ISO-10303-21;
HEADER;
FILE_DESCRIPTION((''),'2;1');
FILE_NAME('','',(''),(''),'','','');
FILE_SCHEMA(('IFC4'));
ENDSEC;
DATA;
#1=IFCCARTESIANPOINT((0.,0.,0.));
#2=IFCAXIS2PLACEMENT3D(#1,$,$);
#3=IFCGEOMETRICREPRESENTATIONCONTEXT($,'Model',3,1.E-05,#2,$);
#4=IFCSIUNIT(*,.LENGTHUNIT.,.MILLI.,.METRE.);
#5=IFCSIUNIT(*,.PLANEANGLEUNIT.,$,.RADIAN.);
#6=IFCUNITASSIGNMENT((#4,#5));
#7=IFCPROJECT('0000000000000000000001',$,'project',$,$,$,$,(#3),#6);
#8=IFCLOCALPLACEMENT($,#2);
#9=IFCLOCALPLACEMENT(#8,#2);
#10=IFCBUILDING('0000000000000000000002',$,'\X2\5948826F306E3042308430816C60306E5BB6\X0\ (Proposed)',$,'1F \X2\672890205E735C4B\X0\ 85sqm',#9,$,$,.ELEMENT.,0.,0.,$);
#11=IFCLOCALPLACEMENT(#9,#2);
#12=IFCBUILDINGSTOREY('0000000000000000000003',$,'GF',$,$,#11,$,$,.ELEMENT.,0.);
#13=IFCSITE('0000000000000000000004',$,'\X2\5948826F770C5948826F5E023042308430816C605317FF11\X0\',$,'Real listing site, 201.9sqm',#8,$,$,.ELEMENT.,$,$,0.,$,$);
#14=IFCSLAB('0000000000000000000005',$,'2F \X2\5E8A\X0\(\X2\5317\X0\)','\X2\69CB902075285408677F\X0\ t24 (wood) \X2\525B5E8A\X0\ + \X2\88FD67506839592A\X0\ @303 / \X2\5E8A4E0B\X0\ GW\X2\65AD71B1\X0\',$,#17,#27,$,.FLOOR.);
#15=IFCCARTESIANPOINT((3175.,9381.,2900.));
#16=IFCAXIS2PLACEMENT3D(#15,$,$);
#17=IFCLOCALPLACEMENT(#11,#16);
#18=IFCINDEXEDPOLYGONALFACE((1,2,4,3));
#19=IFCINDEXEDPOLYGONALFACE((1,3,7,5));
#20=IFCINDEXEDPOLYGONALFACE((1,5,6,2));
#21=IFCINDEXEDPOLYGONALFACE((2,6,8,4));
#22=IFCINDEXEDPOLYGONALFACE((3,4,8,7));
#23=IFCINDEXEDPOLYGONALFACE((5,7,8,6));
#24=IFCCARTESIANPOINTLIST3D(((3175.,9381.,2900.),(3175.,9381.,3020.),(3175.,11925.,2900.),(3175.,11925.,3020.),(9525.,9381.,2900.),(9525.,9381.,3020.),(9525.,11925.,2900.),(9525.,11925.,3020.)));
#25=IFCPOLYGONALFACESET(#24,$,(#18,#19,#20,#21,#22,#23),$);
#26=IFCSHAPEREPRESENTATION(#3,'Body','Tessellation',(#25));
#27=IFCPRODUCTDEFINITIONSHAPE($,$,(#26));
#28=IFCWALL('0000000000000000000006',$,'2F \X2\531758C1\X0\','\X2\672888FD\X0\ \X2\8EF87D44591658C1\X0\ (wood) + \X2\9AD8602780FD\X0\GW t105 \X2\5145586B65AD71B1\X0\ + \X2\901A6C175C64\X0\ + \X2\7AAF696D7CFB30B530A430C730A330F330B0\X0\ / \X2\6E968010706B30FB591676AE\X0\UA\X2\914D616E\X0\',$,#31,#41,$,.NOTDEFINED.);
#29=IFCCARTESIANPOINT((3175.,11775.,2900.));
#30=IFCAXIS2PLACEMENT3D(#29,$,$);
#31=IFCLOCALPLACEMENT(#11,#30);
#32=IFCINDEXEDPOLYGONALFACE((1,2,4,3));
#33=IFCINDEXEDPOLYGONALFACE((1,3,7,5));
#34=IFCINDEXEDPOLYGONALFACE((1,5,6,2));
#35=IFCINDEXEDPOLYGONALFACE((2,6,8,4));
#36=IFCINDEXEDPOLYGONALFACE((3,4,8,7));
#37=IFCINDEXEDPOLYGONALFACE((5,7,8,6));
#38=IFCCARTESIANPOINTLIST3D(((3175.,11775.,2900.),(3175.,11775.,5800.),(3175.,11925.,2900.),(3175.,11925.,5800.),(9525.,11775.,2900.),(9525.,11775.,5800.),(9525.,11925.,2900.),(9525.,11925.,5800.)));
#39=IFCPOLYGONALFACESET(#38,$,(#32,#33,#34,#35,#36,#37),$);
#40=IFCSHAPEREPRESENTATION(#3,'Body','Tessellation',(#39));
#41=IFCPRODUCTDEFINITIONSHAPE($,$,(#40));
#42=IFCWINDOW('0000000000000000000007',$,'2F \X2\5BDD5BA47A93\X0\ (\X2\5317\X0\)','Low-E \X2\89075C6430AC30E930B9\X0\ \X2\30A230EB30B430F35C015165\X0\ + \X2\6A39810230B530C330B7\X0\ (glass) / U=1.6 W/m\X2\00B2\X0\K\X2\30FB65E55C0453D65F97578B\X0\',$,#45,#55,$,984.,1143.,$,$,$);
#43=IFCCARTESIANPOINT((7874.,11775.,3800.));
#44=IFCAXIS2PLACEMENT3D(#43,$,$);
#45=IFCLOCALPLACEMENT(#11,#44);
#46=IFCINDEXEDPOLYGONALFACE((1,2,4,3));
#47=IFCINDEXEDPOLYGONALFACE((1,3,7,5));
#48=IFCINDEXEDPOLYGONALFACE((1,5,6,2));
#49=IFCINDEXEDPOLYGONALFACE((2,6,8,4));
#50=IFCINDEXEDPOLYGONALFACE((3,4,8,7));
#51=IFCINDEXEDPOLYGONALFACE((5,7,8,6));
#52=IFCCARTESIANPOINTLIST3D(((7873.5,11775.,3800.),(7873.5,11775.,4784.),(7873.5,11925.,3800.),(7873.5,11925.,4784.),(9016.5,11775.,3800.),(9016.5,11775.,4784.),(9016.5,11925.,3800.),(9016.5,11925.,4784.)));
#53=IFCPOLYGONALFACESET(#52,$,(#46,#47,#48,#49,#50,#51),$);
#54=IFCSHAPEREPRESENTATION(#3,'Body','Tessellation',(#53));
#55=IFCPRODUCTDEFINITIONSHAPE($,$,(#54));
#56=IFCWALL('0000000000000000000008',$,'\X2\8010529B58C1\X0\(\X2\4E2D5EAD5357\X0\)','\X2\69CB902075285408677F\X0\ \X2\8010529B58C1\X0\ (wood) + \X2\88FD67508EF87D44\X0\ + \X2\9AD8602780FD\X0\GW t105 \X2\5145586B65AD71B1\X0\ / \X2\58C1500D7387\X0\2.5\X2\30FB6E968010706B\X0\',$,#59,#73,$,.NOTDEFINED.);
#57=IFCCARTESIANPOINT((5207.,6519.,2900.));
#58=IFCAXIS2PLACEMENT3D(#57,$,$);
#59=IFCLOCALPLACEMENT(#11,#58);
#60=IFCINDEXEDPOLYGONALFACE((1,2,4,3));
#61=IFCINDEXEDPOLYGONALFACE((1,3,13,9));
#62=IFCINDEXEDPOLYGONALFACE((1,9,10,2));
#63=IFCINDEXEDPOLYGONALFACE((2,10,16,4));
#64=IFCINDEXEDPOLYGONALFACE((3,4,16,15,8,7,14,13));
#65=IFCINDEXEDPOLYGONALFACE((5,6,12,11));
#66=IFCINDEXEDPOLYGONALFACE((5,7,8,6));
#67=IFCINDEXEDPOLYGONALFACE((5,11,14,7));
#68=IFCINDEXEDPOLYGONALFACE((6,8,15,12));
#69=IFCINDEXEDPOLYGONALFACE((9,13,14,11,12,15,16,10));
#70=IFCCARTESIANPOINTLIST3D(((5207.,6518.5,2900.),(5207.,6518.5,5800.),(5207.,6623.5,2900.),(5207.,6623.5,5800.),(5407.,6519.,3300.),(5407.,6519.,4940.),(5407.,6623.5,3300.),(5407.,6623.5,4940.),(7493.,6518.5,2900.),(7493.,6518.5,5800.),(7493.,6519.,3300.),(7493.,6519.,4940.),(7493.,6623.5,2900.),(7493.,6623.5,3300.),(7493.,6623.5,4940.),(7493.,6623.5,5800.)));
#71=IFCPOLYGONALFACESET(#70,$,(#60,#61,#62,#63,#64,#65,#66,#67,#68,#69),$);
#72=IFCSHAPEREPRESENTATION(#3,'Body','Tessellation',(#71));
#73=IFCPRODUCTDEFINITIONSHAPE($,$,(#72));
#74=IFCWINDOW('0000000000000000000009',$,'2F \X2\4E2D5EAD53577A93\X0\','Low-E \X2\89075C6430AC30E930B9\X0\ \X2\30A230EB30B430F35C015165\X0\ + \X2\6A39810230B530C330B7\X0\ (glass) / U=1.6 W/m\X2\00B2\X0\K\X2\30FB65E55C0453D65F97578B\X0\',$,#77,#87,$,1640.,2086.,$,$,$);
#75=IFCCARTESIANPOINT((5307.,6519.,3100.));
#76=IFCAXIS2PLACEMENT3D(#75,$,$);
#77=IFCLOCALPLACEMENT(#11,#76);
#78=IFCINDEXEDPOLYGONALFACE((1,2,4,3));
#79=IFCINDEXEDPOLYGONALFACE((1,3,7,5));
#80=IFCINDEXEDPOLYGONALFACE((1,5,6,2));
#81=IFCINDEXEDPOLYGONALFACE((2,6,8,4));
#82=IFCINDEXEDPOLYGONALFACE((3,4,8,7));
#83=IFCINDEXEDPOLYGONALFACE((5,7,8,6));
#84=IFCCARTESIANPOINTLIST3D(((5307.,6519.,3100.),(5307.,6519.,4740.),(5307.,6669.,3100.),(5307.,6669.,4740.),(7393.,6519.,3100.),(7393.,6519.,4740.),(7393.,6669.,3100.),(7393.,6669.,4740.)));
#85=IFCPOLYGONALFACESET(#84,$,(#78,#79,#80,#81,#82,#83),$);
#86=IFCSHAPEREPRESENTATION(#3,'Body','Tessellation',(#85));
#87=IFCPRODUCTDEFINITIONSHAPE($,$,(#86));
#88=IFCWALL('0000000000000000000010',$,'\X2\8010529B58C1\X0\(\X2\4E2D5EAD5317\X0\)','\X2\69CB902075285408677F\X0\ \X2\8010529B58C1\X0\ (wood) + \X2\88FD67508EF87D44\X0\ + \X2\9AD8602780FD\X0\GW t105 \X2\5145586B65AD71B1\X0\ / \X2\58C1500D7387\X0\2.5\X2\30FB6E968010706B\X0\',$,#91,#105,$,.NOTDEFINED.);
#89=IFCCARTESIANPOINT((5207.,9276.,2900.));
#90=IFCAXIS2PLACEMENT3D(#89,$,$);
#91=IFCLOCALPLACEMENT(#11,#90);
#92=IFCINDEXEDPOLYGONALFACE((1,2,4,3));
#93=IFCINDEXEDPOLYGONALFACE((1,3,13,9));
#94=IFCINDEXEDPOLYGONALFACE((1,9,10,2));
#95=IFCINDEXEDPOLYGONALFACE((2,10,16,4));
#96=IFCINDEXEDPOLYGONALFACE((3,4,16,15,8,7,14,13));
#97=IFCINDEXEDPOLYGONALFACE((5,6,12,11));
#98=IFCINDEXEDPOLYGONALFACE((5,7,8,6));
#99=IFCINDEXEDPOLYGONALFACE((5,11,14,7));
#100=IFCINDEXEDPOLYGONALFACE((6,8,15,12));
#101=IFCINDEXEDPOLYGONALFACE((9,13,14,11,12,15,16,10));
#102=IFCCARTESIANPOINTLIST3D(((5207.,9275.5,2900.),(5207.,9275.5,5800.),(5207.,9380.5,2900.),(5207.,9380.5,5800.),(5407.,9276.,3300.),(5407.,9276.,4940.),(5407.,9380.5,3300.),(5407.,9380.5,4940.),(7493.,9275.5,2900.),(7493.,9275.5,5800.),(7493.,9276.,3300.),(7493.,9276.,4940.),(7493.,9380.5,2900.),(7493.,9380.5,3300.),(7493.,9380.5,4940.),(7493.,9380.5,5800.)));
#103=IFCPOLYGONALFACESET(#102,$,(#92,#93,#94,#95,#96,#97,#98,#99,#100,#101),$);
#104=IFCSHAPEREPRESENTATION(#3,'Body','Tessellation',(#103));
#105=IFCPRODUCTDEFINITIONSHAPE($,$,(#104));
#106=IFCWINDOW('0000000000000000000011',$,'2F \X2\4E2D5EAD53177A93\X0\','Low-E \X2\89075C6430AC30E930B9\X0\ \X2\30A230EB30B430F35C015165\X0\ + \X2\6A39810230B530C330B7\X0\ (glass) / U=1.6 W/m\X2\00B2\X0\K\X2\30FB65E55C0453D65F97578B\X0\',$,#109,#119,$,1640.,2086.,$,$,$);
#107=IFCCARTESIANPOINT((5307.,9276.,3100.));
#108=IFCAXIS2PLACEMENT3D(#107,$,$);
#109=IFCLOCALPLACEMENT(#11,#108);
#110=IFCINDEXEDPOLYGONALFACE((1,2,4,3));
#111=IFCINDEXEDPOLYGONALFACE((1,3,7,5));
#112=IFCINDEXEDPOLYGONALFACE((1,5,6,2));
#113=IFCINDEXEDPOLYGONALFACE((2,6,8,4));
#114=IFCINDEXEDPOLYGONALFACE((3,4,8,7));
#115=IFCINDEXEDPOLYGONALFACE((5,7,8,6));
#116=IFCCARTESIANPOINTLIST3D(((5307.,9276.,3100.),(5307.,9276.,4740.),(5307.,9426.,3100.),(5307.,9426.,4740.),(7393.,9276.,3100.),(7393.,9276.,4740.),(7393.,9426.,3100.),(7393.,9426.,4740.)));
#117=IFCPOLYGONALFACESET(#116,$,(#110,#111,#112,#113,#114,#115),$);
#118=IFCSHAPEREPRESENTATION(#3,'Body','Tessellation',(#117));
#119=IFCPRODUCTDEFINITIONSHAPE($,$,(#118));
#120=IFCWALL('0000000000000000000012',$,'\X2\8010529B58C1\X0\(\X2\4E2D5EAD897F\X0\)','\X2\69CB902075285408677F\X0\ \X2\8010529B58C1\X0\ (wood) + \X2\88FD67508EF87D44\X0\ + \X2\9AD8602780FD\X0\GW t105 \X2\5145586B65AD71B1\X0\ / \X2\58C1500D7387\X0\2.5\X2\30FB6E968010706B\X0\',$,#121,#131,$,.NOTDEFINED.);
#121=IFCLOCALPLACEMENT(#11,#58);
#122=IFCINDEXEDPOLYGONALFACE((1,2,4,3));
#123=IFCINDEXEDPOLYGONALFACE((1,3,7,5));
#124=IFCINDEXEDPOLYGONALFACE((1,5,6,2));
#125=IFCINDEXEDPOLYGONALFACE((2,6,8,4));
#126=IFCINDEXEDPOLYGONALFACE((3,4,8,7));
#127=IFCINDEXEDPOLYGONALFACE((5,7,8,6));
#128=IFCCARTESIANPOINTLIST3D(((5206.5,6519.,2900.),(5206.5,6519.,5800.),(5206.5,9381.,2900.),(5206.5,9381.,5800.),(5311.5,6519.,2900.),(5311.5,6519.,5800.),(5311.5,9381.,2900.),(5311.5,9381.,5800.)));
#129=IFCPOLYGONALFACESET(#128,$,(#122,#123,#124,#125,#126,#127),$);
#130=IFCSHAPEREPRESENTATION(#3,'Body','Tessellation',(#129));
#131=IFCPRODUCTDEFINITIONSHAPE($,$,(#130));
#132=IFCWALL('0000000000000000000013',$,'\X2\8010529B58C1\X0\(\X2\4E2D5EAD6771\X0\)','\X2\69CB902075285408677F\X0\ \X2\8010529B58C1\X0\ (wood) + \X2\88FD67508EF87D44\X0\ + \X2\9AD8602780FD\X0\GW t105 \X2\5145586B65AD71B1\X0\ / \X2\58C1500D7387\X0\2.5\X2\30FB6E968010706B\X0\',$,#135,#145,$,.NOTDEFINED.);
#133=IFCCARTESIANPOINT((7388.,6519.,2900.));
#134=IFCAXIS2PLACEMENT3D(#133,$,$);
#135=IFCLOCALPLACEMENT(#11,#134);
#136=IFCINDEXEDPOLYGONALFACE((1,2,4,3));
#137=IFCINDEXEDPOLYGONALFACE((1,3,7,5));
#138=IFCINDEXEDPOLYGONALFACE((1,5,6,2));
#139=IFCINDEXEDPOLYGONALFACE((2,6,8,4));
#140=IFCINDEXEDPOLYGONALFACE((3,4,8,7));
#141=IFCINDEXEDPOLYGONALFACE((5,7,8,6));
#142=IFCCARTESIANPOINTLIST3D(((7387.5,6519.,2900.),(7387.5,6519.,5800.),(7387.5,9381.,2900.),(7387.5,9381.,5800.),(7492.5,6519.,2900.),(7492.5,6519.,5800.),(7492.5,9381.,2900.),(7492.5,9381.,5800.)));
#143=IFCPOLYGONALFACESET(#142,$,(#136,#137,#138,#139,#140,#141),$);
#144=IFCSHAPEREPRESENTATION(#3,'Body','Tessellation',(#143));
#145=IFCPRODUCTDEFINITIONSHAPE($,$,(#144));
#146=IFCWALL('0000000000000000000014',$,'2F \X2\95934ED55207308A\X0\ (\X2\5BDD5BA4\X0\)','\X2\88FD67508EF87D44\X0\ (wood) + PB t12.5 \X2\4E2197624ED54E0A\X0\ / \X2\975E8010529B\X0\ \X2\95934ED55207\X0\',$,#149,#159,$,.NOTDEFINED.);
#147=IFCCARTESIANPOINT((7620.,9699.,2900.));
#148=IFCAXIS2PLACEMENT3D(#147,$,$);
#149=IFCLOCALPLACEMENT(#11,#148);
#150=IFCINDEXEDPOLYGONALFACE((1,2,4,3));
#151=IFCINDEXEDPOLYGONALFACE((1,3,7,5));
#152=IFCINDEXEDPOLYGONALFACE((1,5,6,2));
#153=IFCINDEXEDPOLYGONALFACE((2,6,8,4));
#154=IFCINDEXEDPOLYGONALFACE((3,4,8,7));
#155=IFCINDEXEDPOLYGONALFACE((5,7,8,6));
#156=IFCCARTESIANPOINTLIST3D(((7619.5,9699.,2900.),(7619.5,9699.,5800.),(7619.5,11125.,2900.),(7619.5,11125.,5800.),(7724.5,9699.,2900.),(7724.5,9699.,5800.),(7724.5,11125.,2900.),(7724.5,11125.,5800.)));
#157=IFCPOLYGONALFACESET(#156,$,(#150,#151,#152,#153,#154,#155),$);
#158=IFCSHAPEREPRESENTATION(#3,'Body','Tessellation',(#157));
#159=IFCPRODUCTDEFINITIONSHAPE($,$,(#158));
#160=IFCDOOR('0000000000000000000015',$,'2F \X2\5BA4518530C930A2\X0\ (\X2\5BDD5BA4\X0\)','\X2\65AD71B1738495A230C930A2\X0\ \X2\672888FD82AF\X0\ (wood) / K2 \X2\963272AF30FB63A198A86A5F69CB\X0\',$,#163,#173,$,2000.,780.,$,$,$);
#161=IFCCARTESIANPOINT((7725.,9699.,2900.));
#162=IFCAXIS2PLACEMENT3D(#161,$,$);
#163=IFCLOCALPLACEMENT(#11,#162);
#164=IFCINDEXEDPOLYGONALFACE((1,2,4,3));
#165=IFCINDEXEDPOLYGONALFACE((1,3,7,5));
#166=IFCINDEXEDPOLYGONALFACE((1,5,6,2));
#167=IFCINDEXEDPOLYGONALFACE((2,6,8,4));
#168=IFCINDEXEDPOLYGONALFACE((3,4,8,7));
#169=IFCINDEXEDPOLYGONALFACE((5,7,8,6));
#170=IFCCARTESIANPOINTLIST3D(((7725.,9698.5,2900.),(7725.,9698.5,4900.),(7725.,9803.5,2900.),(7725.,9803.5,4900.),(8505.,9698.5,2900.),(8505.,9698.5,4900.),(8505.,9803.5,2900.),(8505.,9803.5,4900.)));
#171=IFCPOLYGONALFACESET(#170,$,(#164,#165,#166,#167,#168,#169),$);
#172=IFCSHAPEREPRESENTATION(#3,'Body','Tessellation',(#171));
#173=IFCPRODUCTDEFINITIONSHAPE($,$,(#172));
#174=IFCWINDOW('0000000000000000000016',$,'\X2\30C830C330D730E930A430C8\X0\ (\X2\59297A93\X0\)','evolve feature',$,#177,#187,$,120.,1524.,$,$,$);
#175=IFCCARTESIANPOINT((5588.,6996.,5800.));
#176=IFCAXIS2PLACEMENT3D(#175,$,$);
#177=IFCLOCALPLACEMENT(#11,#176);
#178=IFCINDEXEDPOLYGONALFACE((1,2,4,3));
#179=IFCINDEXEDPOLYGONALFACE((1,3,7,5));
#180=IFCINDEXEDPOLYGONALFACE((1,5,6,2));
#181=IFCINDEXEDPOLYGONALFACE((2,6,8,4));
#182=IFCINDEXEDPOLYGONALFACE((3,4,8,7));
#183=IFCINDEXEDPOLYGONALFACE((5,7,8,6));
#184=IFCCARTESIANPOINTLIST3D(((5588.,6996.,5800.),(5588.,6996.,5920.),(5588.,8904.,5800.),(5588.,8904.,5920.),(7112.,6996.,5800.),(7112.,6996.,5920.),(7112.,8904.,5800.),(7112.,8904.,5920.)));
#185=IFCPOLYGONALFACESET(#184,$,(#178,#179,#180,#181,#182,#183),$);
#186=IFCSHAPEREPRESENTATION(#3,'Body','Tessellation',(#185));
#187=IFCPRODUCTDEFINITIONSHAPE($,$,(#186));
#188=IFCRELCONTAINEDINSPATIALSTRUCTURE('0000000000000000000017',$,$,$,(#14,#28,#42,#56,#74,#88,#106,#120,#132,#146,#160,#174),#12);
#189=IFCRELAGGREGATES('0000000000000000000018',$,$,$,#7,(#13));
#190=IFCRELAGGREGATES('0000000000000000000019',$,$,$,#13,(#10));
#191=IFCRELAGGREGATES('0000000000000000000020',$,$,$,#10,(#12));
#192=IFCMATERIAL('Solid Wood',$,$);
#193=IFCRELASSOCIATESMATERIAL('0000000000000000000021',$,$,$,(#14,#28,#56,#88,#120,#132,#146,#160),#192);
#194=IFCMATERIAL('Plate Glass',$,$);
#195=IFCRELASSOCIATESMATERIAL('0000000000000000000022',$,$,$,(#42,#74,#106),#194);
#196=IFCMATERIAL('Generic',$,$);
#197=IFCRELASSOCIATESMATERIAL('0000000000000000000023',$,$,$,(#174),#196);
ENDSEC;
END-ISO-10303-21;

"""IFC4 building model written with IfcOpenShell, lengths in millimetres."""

from ifc_helpers import new_model, si_unit, frame, frame_2d, origin, place, context, project, spatial, rectangle, extrude, material, element, fill, save


model = new_model("IFC4")

# Units and contexts
model_context = context("Model", 3, precision=1e-05, world=origin())
ifc_project = project(units=[si_unit("LENGTHUNIT", "METRE", prefix="MILLI"), si_unit("PLANEANGLEUNIT", "RADIAN")], contexts=[model_context])

# Site, building, storey
site_placement = place(None, origin())
site = spatial("IfcSite", under=ifc_project, at=site_placement, Name="奈良県奈良市あやめ池北１", ObjectType="Real listing site, 201.9sqm", CompositionType="ELEMENT", RefElevation=0.0)
building_placement = place(site_placement, origin())
building = spatial("IfcBuilding", under=site, at=building_placement, Name="奈良のあやめ池の家 (Proposed)", ObjectType="1F 木造平屋 85sqm", CompositionType="ELEMENT", ElevationOfRefHeight=0.0, ElevationOfTerrain=0.0)
storey_placement = place(building_placement, origin())
storey = spatial("IfcBuildingStorey", under=building, at=storey_placement, Name="GF", CompositionType="ELEMENT", Elevation=0.0)

# Slab
ifc_material_1 = material(Name="Solid Wood")
slab_placement = place(storey_placement, frame((3175.0, 9381.0, 2900.0)))
element("IfcSlab", 1, at=slab_placement, inside=storey, material=ifc_material_1, Name="2F 床(北)", Description="構造用合板 t24 (wood) 剛床 + 製材根太 @303 / 床下 GW断熱", PredefinedType="FLOOR", context=model_context, shape_type="SweptSolid", body=[
    extrude(rectangle(XDim=6350.0, YDim=2544.0, at=frame_2d((3175.0, 1272.0))), frame((3175.0, 9381.0, 2900.0)), (0.0, 0.0, 1.0), 120.0),
])

# Walls, openings, windows
wall_1_placement = place(storey_placement, frame((3175.0, 11775.0, 2900.0)))
wall_1 = element("IfcWall", 2, at=wall_1_placement, inside=storey, material=ifc_material_1, Name="2F 北壁", Description="木製 軸組外壁 (wood) + 高性能GW t105 充填断熱 + 通気層 + 窯業系サイディング / 準耐火・外皮UA配慮", PredefinedType="NOTDEFINED", context=model_context, shape_type="SweptSolid", body=[
    extrude(rectangle(XDim=6350.0, YDim=150.0, at=frame_2d((3175.0, 75.0))), frame((3175.0, 11775.0, 2900.0)), (0.0, 0.0, 1.0), 2900.0),
])
opening_1_placement = place(storey_placement, frame((7874.0, 11775.0, 3800.0)))
opening_1 = element("IfcOpeningElement", 3, at=opening_1_placement, cuts=wall_1, PredefinedType="NOTDEFINED", context=model_context, shape_type="SweptSolid", body=[
    extrude(rectangle(XDim=1143.0, YDim=150.0, at=frame_2d((571.0, 75.0))), frame((7874.0, 11775.0, 3800.0)), (0.0, 0.0, 1.0), 984.0),
])
ifc_material_2 = material(Name="Plate Glass")
window_1_placement = place(storey_placement, frame((7874.0, 11775.0, 3800.0)))
window_1 = element("IfcWindow", 4, at=window_1_placement, inside=storey, material=ifc_material_2, Name="2F 寝室窓 (北)", Description="Low-E 複層ガラス アルゴン封入 + 樹脂サッシ (glass) / U=1.6 W/m²K・日射取得型", OverallHeight=984.0, OverallWidth=1143.0, context=model_context, shape_type="SweptSolid", body=[
    extrude(rectangle(XDim=1143.0, YDim=150.0, at=frame_2d((571.0, 75.0))), frame((7874.0, 11775.0, 3800.0)), (0.0, 0.0, 1.0), 984.0),
])
fill(opening_1, window_1)
wall_2_placement = place(storey_placement, frame((5207.0, 6519.0, 2900.0)))
wall_2 = element("IfcWall", 5, at=wall_2_placement, inside=storey, material=ifc_material_1, Name="耐力壁(中庭南)", Description="構造用合板 耐力壁 (wood) + 製材軸組 + 高性能GW t105 充填断熱 / 壁倍率2.5・準耐火", PredefinedType="NOTDEFINED", context=model_context, shape_type="SweptSolid", body=[
    extrude(rectangle(XDim=2286.0, YDim=105.0, at=frame_2d((1143.0, 52.0))), frame((5207.0, 6519.0, 2900.0)), (0.0, 0.0, 1.0), 2900.0),
])
opening_2_placement = place(storey_placement, frame((5307.0, 6519.0, 3100.0)))
opening_2 = element("IfcOpeningElement", 6, at=opening_2_placement, cuts=wall_2, PredefinedType="NOTDEFINED", context=model_context, shape_type="SweptSolid", body=[
    extrude(rectangle(XDim=2086.0, YDim=150.0, at=frame_2d((1043.0, 75.0))), frame((5307.0, 6519.0, 3100.0)), (0.0, 0.0, 1.0), 1640.0),
])
window_2_placement = place(storey_placement, frame((5307.0, 6519.0, 3100.0)))
window_2 = element("IfcWindow", 7, at=window_2_placement, inside=storey, material=ifc_material_2, Name="2F 中庭南窓", Description="Low-E 複層ガラス アルゴン封入 + 樹脂サッシ (glass) / U=1.6 W/m²K・日射取得型", OverallHeight=1640.0, OverallWidth=2086.0, context=model_context, shape_type="SweptSolid", body=[
    extrude(rectangle(XDim=2086.0, YDim=150.0, at=frame_2d((1043.0, 75.0))), frame((5307.0, 6519.0, 3100.0)), (0.0, 0.0, 1.0), 1640.0),
])
fill(opening_2, window_2)
wall_3_placement = place(storey_placement, frame((5207.0, 9276.0, 2900.0)))
wall_3 = element("IfcWall", 8, at=wall_3_placement, inside=storey, material=ifc_material_1, Name="耐力壁(中庭北)", Description="構造用合板 耐力壁 (wood) + 製材軸組 + 高性能GW t105 充填断熱 / 壁倍率2.5・準耐火", PredefinedType="NOTDEFINED", context=model_context, shape_type="SweptSolid", body=[
    extrude(rectangle(XDim=2286.0, YDim=105.0, at=frame_2d((1143.0, 52.0))), frame((5207.0, 9276.0, 2900.0)), (0.0, 0.0, 1.0), 2900.0),
])
opening_3_placement = place(storey_placement, frame((5307.0, 9276.0, 3100.0)))
opening_3 = element("IfcOpeningElement", 9, at=opening_3_placement, cuts=wall_3, PredefinedType="NOTDEFINED", context=model_context, shape_type="SweptSolid", body=[
    extrude(rectangle(XDim=2086.0, YDim=150.0, at=frame_2d((1043.0, 75.0))), frame((5307.0, 9276.0, 3100.0)), (0.0, 0.0, 1.0), 1640.0),
])
window_3_placement = place(storey_placement, frame((5307.0, 9276.0, 3100.0)))
window_3 = element("IfcWindow", 10, at=window_3_placement, inside=storey, material=ifc_material_2, Name="2F 中庭北窓", Description="Low-E 複層ガラス アルゴン封入 + 樹脂サッシ (glass) / U=1.6 W/m²K・日射取得型", OverallHeight=1640.0, OverallWidth=2086.0, context=model_context, shape_type="SweptSolid", body=[
    extrude(rectangle(XDim=2086.0, YDim=150.0, at=frame_2d((1043.0, 75.0))), frame((5307.0, 9276.0, 3100.0)), (0.0, 0.0, 1.0), 1640.0),
])
fill(opening_3, window_3)

# Walls
wall_4_placement = place(storey_placement, frame((5207.0, 6519.0, 2900.0)))
element("IfcWall", 11, at=wall_4_placement, inside=storey, material=ifc_material_1, Name="耐力壁(中庭西)", Description="構造用合板 耐力壁 (wood) + 製材軸組 + 高性能GW t105 充填断熱 / 壁倍率2.5・準耐火", PredefinedType="NOTDEFINED", context=model_context, shape_type="SweptSolid", body=[
    extrude(rectangle(XDim=105.0, YDim=2862.0, at=frame_2d((52.0, 1431.0))), frame((5207.0, 6519.0, 2900.0)), (0.0, 0.0, 1.0), 2900.0),
])
wall_5_placement = place(storey_placement, frame((7388.0, 6519.0, 2900.0)))
element("IfcWall", 12, at=wall_5_placement, inside=storey, material=ifc_material_1, Name="耐力壁(中庭東)", Description="構造用合板 耐力壁 (wood) + 製材軸組 + 高性能GW t105 充填断熱 / 壁倍率2.5・準耐火", PredefinedType="NOTDEFINED", context=model_context, shape_type="SweptSolid", body=[
    extrude(rectangle(XDim=105.0, YDim=2862.0, at=frame_2d((52.0, 1431.0))), frame((7388.0, 6519.0, 2900.0)), (0.0, 0.0, 1.0), 2900.0),
])
wall_6_placement = place(storey_placement, frame((7620.0, 9699.0, 2900.0)))
element("IfcWall", 13, at=wall_6_placement, inside=storey, material=ifc_material_1, Name="2F 間仕切り (寝室)", Description="製材軸組 (wood) + PB t12.5 両面仕上 / 非耐力 間仕切", PredefinedType="NOTDEFINED", context=model_context, shape_type="SweptSolid", body=[
    extrude(rectangle(XDim=105.0, YDim=1426.0, at=frame_2d((52.0, 713.0))), frame((7620.0, 9699.0, 2900.0)), (0.0, 0.0, 1.0), 2900.0),
])

# Door
door_placement = place(storey_placement, frame((7725.0, 9699.0, 2900.0)))
element("IfcDoor", 14, at=door_placement, inside=storey, material=ifc_material_1, Name="2F 室内ドア (寝室)", Description="断熱玄関ドア 木製芯 (wood) / K2 防犯・採風機構", OverallHeight=2000.0, OverallWidth=780.0, context=model_context, shape_type="SweptSolid", body=[
    extrude(rectangle(XDim=780.0, YDim=105.0, at=frame_2d((390.0, 52.0))), frame((7725.0, 9699.0, 2900.0)), (0.0, 0.0, 1.0), 2000.0),
])

# Window
ifc_material_3 = material(Name="Generic")
window_4_placement = place(storey_placement, frame((5588.0, 6996.0, 5800.0)))
element("IfcWindow", 15, at=window_4_placement, inside=storey, material=ifc_material_3, Name="トップライト (天窓)", Description="evolve feature", OverallHeight=120.0, OverallWidth=1524.0, context=model_context, shape_type="SweptSolid", body=[
    extrude(rectangle(XDim=1524.0, YDim=1908.0, at=frame_2d((762.0, 954.0))), frame((5588.0, 6996.0, 5800.0)), (0.0, 0.0, 1.0), 120.0),
])

save(model, "model.ifc")
